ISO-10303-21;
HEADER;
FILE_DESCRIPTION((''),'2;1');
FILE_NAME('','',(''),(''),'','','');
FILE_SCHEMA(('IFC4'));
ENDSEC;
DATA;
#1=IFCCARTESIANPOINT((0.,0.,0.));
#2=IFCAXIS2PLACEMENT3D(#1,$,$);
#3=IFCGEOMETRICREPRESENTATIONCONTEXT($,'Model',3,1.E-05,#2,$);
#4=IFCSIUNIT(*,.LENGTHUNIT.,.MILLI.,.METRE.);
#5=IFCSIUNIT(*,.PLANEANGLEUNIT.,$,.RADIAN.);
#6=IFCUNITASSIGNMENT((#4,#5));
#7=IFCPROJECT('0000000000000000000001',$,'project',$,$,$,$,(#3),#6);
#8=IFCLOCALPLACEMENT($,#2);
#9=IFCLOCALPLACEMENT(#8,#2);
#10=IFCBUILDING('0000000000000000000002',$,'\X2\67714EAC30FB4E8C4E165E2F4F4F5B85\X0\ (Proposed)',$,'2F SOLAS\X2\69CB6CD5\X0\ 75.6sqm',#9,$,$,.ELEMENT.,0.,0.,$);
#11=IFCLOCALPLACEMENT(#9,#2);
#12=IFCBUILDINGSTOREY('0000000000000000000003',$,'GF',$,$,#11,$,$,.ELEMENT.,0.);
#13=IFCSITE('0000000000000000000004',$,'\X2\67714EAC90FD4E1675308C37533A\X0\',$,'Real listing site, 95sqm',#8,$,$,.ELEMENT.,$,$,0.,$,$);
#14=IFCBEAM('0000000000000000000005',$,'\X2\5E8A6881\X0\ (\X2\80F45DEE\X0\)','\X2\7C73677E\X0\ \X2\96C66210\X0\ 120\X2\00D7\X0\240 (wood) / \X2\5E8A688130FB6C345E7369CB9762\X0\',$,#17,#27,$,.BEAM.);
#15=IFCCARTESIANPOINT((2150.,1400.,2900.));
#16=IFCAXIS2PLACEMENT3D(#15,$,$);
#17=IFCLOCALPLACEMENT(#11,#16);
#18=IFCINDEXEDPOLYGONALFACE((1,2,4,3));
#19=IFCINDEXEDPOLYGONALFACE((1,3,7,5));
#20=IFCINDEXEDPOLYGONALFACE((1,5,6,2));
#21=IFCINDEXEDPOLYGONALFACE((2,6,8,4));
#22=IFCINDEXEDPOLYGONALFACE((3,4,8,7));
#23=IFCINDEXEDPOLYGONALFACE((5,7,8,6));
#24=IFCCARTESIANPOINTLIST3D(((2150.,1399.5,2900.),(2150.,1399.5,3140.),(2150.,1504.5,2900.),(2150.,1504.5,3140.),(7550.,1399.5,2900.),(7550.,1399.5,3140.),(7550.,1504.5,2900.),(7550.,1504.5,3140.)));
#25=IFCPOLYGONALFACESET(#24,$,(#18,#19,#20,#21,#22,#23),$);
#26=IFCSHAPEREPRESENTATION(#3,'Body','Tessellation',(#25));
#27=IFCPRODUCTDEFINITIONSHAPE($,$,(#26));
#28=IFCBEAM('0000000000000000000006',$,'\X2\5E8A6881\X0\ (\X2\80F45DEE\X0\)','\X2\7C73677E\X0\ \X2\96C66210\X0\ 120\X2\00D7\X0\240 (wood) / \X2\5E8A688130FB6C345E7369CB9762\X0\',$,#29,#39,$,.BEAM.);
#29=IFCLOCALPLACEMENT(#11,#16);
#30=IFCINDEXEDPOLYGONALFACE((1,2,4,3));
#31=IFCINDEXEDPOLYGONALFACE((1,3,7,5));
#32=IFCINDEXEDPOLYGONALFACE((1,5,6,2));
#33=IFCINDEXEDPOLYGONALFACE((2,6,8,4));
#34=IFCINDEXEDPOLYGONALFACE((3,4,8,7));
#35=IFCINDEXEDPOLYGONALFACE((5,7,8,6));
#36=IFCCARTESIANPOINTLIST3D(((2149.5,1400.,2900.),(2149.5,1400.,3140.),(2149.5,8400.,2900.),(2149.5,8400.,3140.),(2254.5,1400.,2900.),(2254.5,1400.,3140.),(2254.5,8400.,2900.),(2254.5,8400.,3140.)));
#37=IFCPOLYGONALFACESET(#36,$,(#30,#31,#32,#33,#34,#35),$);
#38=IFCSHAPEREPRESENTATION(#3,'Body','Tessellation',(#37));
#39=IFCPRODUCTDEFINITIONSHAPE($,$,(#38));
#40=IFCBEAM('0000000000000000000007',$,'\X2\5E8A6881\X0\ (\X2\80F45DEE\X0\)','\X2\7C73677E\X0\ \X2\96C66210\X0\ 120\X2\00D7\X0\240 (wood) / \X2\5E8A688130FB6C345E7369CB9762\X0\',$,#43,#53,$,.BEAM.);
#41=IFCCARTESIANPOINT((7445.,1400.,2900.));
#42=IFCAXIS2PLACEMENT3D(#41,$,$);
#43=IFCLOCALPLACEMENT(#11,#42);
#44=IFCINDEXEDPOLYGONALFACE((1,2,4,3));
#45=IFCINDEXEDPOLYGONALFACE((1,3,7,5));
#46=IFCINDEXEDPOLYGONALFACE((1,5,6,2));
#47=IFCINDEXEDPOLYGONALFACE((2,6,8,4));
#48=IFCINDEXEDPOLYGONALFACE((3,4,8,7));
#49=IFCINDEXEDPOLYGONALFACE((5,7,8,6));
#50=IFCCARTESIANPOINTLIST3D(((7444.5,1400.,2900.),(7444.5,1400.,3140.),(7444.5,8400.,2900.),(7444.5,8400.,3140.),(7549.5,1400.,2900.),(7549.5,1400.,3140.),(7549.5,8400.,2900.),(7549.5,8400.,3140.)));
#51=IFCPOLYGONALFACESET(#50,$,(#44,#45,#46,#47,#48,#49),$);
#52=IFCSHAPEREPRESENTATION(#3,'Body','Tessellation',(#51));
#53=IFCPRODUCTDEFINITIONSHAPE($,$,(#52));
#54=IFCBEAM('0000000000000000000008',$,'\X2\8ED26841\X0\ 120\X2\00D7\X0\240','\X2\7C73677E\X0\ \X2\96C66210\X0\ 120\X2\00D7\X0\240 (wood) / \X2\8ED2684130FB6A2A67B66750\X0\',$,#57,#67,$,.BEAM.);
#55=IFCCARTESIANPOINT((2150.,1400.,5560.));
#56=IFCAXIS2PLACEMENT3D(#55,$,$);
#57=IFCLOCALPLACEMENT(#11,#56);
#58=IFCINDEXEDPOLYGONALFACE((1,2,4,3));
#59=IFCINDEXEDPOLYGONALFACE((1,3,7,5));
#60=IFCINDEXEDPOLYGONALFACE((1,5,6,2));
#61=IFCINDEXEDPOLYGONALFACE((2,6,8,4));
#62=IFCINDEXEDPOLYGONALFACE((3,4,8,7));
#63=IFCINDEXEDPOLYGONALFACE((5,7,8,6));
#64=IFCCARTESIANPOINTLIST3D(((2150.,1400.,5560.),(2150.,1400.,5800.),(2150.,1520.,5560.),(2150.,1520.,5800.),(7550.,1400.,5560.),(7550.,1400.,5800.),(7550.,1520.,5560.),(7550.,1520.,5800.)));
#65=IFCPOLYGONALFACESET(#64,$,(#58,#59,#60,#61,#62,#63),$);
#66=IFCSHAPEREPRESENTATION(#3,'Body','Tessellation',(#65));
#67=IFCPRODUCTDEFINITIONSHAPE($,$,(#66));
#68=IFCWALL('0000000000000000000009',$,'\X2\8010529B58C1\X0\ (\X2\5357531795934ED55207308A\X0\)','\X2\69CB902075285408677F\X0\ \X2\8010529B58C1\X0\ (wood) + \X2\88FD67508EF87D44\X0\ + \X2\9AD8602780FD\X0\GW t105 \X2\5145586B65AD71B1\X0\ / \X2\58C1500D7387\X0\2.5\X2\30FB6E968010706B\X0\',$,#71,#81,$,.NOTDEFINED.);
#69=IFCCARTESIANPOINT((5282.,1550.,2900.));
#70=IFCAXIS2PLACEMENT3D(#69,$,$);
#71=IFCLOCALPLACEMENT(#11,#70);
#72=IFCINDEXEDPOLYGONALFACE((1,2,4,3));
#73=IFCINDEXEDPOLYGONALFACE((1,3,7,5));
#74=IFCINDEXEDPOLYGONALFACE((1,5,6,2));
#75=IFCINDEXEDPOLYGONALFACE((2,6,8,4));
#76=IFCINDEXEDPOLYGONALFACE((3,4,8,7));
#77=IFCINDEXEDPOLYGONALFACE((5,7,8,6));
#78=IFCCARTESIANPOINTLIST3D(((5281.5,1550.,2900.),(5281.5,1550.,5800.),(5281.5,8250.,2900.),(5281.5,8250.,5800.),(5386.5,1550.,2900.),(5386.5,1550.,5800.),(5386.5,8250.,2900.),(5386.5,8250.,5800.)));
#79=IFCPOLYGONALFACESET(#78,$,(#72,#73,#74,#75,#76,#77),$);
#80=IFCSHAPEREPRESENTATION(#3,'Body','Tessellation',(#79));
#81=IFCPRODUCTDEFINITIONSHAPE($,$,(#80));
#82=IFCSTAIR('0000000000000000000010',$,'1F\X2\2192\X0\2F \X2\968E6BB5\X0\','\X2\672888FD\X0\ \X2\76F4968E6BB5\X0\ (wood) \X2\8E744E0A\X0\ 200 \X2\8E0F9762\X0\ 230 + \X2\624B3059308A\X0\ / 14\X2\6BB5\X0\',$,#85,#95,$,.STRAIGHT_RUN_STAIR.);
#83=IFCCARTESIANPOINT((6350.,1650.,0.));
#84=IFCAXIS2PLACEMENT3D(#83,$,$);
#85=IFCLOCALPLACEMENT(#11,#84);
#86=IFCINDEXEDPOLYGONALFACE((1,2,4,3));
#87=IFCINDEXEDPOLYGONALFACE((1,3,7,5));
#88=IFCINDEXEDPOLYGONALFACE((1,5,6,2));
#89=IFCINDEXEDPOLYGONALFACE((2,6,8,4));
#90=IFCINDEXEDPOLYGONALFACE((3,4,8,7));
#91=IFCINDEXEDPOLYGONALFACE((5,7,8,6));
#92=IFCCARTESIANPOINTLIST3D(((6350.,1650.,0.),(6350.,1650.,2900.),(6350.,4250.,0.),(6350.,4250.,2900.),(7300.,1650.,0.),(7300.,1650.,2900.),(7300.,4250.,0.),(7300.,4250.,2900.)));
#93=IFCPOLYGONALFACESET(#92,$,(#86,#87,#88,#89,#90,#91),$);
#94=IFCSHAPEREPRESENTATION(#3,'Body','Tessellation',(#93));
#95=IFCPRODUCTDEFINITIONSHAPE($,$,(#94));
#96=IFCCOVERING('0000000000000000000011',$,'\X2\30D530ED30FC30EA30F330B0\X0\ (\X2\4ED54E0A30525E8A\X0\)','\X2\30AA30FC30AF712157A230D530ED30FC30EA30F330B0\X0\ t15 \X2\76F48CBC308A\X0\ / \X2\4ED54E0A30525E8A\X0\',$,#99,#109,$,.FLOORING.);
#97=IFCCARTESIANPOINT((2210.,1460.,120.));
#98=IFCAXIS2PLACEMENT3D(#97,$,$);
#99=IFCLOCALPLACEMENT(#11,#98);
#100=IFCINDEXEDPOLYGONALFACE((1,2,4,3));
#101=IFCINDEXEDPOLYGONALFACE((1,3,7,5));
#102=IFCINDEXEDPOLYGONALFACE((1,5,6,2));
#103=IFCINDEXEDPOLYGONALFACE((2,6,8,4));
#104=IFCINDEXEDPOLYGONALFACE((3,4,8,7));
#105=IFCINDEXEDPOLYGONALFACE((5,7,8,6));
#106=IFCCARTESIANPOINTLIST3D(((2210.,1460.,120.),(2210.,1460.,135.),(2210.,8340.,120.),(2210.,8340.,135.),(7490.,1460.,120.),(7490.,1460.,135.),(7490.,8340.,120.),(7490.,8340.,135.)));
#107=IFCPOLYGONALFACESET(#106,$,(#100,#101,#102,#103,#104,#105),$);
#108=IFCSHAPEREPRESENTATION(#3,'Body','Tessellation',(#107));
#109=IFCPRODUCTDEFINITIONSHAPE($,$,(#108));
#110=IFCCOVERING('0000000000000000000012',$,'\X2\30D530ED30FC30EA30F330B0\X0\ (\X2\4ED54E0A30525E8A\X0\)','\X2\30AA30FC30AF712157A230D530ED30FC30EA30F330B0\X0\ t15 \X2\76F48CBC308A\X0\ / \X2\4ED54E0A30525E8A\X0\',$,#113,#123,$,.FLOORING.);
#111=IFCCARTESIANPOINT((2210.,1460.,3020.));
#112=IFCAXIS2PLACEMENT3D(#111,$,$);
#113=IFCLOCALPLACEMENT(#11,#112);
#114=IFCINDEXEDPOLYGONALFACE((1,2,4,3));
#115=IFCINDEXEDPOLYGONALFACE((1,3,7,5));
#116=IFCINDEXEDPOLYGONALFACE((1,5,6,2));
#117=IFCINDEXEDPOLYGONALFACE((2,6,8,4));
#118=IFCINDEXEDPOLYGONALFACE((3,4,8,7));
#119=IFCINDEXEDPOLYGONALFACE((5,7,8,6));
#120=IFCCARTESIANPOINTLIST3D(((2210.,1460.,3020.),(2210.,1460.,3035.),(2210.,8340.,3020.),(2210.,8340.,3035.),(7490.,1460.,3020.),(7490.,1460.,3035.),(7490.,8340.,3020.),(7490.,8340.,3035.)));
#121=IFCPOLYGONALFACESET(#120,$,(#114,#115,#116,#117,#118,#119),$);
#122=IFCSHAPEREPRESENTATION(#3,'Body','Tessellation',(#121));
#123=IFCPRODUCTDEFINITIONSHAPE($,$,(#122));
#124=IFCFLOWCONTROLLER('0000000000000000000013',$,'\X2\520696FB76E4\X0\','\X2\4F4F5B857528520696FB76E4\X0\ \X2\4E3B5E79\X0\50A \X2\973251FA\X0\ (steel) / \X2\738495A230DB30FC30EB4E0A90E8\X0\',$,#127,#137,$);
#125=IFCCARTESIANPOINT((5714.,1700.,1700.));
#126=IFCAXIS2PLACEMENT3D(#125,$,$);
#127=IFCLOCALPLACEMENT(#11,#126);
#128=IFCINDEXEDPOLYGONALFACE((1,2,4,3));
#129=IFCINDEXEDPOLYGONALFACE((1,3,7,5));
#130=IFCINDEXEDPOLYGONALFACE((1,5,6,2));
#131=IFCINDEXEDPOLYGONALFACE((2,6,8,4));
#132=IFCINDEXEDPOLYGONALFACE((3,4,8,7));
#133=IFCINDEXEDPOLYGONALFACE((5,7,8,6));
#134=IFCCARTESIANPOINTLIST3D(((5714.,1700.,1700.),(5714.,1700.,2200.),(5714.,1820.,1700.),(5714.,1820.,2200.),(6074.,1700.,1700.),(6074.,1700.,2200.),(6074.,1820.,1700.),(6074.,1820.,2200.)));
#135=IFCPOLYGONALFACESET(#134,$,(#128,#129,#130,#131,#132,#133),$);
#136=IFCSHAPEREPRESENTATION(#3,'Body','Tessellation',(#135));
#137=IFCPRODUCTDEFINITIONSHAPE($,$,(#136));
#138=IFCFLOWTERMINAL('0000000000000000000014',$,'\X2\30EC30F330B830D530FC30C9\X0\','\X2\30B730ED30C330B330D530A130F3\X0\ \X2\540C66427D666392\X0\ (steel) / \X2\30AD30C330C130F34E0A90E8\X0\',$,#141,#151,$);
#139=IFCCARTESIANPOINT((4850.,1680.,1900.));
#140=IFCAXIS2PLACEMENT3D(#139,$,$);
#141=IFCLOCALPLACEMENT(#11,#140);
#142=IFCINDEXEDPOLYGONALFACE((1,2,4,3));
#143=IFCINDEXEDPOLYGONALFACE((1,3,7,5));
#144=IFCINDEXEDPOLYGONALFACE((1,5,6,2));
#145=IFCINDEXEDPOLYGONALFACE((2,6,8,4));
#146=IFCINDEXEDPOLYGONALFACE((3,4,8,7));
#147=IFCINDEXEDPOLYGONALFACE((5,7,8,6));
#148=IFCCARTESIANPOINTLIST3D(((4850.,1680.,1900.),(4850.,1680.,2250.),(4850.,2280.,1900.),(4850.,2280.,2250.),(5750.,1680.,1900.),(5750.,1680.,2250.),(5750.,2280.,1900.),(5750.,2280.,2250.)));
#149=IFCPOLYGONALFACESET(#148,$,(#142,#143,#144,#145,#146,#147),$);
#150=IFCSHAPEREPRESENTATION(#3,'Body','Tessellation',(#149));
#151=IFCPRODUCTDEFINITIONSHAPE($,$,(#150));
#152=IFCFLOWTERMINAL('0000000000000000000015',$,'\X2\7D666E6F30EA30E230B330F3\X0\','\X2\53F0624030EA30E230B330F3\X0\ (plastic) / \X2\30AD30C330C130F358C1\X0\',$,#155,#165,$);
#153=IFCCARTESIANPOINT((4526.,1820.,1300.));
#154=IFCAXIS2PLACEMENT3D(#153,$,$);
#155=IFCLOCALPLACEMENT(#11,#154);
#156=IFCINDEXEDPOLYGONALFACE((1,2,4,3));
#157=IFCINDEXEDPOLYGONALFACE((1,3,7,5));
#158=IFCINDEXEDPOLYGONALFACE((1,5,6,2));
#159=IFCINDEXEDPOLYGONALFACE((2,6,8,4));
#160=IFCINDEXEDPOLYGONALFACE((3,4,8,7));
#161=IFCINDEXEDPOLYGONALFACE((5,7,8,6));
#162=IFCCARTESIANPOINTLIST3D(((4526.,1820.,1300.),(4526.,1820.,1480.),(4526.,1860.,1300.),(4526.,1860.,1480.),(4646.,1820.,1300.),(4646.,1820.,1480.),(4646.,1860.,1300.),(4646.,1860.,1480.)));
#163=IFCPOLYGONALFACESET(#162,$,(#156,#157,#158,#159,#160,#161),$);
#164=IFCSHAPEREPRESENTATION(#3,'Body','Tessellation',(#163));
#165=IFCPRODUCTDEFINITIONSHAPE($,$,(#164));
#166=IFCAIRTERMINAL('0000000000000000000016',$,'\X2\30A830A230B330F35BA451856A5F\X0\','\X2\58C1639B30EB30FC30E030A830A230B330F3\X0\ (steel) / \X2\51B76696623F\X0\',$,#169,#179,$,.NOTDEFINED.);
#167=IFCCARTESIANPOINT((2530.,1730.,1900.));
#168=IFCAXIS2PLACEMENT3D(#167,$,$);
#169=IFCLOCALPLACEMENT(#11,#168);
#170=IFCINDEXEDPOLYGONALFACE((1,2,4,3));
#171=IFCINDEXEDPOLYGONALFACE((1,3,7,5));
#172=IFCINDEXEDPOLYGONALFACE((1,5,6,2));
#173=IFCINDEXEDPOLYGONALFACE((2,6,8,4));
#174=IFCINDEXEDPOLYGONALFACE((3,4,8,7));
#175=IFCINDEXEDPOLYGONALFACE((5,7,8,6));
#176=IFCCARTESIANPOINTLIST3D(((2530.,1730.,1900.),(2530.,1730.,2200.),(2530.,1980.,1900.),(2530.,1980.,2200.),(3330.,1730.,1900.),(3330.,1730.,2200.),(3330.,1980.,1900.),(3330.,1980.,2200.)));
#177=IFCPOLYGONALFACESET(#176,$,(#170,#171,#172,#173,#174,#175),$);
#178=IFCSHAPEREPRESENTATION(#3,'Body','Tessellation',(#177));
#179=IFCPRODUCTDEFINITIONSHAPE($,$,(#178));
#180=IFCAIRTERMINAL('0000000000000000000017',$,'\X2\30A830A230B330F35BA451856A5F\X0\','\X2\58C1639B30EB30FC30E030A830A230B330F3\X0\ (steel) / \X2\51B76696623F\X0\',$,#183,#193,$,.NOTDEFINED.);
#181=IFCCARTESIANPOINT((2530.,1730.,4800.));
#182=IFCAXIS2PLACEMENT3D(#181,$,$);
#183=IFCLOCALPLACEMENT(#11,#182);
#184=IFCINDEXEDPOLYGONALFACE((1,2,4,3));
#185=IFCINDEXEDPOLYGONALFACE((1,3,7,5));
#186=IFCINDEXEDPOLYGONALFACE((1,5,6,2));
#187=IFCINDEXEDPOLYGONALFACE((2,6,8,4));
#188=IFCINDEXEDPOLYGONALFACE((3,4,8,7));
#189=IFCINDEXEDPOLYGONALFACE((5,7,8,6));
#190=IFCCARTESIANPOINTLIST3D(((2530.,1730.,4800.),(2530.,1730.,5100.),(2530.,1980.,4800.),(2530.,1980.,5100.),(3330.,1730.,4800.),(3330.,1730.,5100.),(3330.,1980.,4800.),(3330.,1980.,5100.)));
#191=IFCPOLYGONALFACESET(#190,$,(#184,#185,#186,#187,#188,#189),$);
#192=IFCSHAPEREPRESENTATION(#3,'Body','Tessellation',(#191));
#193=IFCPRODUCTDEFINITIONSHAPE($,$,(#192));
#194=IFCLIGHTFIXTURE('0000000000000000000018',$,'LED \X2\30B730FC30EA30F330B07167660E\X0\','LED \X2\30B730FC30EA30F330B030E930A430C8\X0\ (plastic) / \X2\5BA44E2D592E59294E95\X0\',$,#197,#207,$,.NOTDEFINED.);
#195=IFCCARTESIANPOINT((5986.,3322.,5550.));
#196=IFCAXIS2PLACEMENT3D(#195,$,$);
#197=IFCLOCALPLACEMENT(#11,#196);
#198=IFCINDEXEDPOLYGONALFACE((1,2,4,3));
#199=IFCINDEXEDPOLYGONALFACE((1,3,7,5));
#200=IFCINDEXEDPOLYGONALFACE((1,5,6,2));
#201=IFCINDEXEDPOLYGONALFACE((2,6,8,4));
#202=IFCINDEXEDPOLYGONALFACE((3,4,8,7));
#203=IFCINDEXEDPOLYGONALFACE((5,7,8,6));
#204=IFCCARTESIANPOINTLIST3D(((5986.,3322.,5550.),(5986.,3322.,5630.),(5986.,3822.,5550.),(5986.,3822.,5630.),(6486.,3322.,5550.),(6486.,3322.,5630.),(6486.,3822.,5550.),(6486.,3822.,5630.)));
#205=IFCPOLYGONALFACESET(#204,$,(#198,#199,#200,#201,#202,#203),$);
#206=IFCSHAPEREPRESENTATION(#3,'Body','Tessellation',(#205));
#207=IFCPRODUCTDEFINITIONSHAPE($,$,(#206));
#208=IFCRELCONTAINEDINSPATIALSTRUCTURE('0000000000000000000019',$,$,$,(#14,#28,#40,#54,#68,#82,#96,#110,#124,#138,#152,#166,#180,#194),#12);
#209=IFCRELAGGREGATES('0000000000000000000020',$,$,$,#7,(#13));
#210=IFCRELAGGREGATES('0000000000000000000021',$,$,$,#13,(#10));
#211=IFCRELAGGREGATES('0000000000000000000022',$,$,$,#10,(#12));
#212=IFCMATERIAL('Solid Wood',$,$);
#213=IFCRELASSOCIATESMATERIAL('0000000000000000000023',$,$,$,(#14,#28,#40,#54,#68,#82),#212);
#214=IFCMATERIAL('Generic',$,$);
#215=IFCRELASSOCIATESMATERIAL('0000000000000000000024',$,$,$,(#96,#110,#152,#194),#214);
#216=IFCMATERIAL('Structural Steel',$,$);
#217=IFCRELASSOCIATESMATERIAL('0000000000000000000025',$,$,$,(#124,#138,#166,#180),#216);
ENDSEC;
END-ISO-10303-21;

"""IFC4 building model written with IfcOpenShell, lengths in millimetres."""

from ifc_helpers import new_model, si_unit, frame, frame_2d, origin, place, context, project, spatial, rectangle, extrude, material, element, save


model = new_model("IFC4")

# Units and contexts
model_context = context("Model", 3, precision=1e-05, world=origin())
ifc_project = project(units=[si_unit("LENGTHUNIT", "METRE", prefix="MILLI"), si_unit("PLANEANGLEUNIT", "RADIAN")], contexts=[model_context])

# Site, building, storey
site_placement = place(None, origin())
site = spatial("IfcSite", under=ifc_project, at=site_placement, Name="東京都世田谷区", ObjectType="Real listing site, 95sqm", CompositionType="ELEMENT", RefElevation=0.0)
building_placement = place(site_placement, origin())
building = spatial("IfcBuilding", under=site, at=building_placement, Name="東京・二世帯住宅 (Proposed)", ObjectType="2F SOLAS構法 75.6sqm", CompositionType="ELEMENT", ElevationOfRefHeight=0.0, ElevationOfTerrain=0.0)
storey_placement = place(building_placement, origin())
storey = spatial("IfcBuildingStorey", under=building, at=storey_placement, Name="GF", CompositionType="ELEMENT", Elevation=0.0)

# Shared definitions
ifc_material_1 = material(Name="Solid Wood")

# Beams
beam_1_placement = place(storey_placement, frame((2150.0, 1400.0, 2900.0)))
element("IfcBeam", 1, at=beam_1_placement, inside=storey, material=ifc_material_1, Name="床梁 (胴差)", Description="米松 集成 120×240 (wood) / 床梁・水平構面", PredefinedType="BEAM", context=model_context, shape_type="SweptSolid", body=[
    extrude(rectangle(XDim=5400.0, YDim=105.0, at=frame_2d((2700.0, 52.0))), frame((2150.0, 1400.0, 2900.0)), (0.0, 0.0, 1.0), 240.0),
])
beam_2_placement = place(storey_placement, frame((2150.0, 1400.0, 2900.0)))
element("IfcBeam", 2, at=beam_2_placement, inside=storey, material=ifc_material_1, Name="床梁 (胴差)", Description="米松 集成 120×240 (wood) / 床梁・水平構面", PredefinedType="BEAM", context=model_context, shape_type="SweptSolid", body=[
    extrude(rectangle(XDim=105.0, YDim=7000.0, at=frame_2d((52.0, 3500.0))), frame((2150.0, 1400.0, 2900.0)), (0.0, 0.0, 1.0), 240.0),
])
beam_3_placement = place(storey_placement, frame((7445.0, 1400.0, 2900.0)))
element("IfcBeam", 3, at=beam_3_placement, inside=storey, material=ifc_material_1, Name="床梁 (胴差)", Description="米松 集成 120×240 (wood) / 床梁・水平構面", PredefinedType="BEAM", context=model_context, shape_type="SweptSolid", body=[
    extrude(rectangle(XDim=105.0, YDim=7000.0, at=frame_2d((52.0, 3500.0))), frame((7445.0, 1400.0, 2900.0)), (0.0, 0.0, 1.0), 240.0),
])
beam_4_placement = place(storey_placement, frame((2150.0, 1400.0, 5560.0)))
element("IfcBeam", 4, at=beam_4_placement, inside=storey, material=ifc_material_1, Name="軒桁 120×240", Description="米松 集成 120×240 (wood) / 軒桁・横架材", PredefinedType="BEAM", context=model_context, shape_type="SweptSolid", body=[
    extrude(rectangle(XDim=5400.0, YDim=120.0, at=frame_2d((2700.0, 60.0))), frame((2150.0, 1400.0, 5560.0)), (0.0, 0.0, 1.0), 240.0),
])

# Wall
wall_1_placement = place(storey_placement, frame((5282.0, 1550.0, 2900.0)))
element("IfcWall", 5, at=wall_1_placement, inside=storey, material=ifc_material_1, Name="耐力壁 (南北間仕切り)", Description="構造用合板 耐力壁 (wood) + 製材軸組 + 高性能GW t105 充填断熱 / 壁倍率2.5・準耐火", PredefinedType="NOTDEFINED", context=model_context, shape_type="SweptSolid", body=[
    extrude(rectangle(XDim=105.0, YDim=6700.0, at=frame_2d((52.0, 3350.0))), frame((5282.0, 1550.0, 2900.0)), (0.0, 0.0, 1.0), 2900.0),
])

# Stair
stair_placement = place(storey_placement, frame((6350.0, 1650.0, 0.0)))
element("IfcStair", 6, at=stair_placement, inside=storey, material=ifc_material_1, Name="1F→2F 階段", Description="木製 直階段 (wood) 蹴上 200 踏面 230 + 手すり / 14段", PredefinedType="STRAIGHT_RUN_STAIR", context=model_context, shape_type="SweptSolid", body=[
    extrude(rectangle(XDim=950.0, YDim=2600.0, at=frame_2d((475.0, 1300.0))), frame((6350.0, 1650.0, 0.0)), (0.0, 0.0, 1.0), 2900.0),
])

# Coverings
ifc_material_2 = material(Name="Generic")
covering_1_placement = place(storey_placement, frame((2210.0, 1460.0, 120.0)))
element("IfcCovering", 7, at=covering_1_placement, inside=storey, material=ifc_material_2, Name="フローリング (仕上げ床)", Description="オーク無垢フローリング t15 直貼り / 仕上げ床", PredefinedType="FLOORING", context=model_context, shape_type="SweptSolid", body=[
    extrude(rectangle(XDim=5280.0, YDim=6880.0, at=frame_2d((2640.0, 3440.0))), frame((2210.0, 1460.0, 120.0)), (0.0, 0.0, 1.0), 15.0),
])
covering_2_placement = place(storey_placement, frame((2210.0, 1460.0, 3020.0)))
element("IfcCovering", 8, at=covering_2_placement, inside=storey, material=ifc_material_2, Name="フローリング (仕上げ床)", Description="オーク無垢フローリング t15 直貼り / 仕上げ床", PredefinedType="FLOORING", context=model_context, shape_type="SweptSolid", body=[
    extrude(rectangle(XDim=5280.0, YDim=6880.0, at=frame_2d((2640.0, 3440.0))), frame((2210.0, 1460.0, 3020.0)), (0.0, 0.0, 1.0), 15.0),
])

# Flow controller
ifc_material_3 = material(Name="Structural Steel")
flow_controller_placement = place(storey_placement, frame((5714.0, 1700.0, 1700.0)))
element("IfcFlowController", 9, at=flow_controller_placement, inside=storey, material=ifc_material_3, Name="分電盤", Description="住宅用分電盤 主幹50A 露出 (steel) / 玄関ホール上部", context=model_context, shape_type="SweptSolid", body=[
    extrude(rectangle(XDim=360.0, YDim=120.0, at=frame_2d((180.0, 60.0))), frame((5714.0, 1700.0, 1700.0)), (0.0, 0.0, 1.0), 500.0),
])

# Flow terminals
flow_terminal_1_placement = place(storey_placement, frame((4850.0, 1680.0, 1900.0)))
element("IfcFlowTerminal", 10, at=flow_terminal_1_placement, inside=storey, material=ifc_material_3, Name="レンジフード", Description="シロッコファン 同時給排 (steel) / キッチン上部", context=model_context, shape_type="SweptSolid", body=[
    extrude(rectangle(XDim=900.0, YDim=600.0, at=frame_2d((450.0, 300.0))), frame((4850.0, 1680.0, 1900.0)), (0.0, 0.0, 1.0), 350.0),
])
flow_terminal_2_placement = place(storey_placement, frame((4526.0, 1820.0, 1300.0)))
element("IfcFlowTerminal", 11, at=flow_terminal_2_placement, inside=storey, material=ifc_material_2, Name="給湯リモコン", Description="台所リモコン (plastic) / キッチン壁", context=model_context, shape_type="SweptSolid", body=[
    extrude(rectangle(XDim=120.0, YDim=40.0, at=frame_2d((60.0, 20.0))), frame((4526.0, 1820.0, 1300.0)), (0.0, 0.0, 1.0), 180.0),
])

# Air terminals
air_terminal_1_placement = place(storey_placement, frame((2530.0, 1730.0, 1900.0)))
element("IfcAirTerminal", 12, at=air_terminal_1_placement, inside=storey, material=ifc_material_3, Name="エアコン室内機", Description="壁掛ルームエアコン (steel) / 冷暖房", PredefinedType="NOTDEFINED", context=model_context, shape_type="SweptSolid", body=[
    extrude(rectangle(XDim=800.0, YDim=250.0, at=frame_2d((400.0, 125.0))), frame((2530.0, 1730.0, 1900.0)), (0.0, 0.0, 1.0), 300.0),
])
air_terminal_2_placement = place(storey_placement, frame((2530.0, 1730.0, 4800.0)))
element("IfcAirTerminal", 13, at=air_terminal_2_placement, inside=storey, material=ifc_material_3, Name="エアコン室内機", Description="壁掛ルームエアコン (steel) / 冷暖房", PredefinedType="NOTDEFINED", context=model_context, shape_type="SweptSolid", body=[
    extrude(rectangle(XDim=800.0, YDim=250.0, at=frame_2d((400.0, 125.0))), frame((2530.0, 1730.0, 4800.0)), (0.0, 0.0, 1.0), 300.0),
])

# Light fixture
light_fixture_placement = place(storey_placement, frame((5986.0, 3322.0, 5550.0)))
element("IfcLightFixture", 14, at=light_fixture_placement, inside=storey, material=ifc_material_2, Name="LED シーリング照明", Description="LED シーリングライト (plastic) / 室中央天井", PredefinedType="NOTDEFINED", context=model_context, shape_type="SweptSolid", body=[
    extrude(rectangle(XDim=500.0, YDim=500.0, at=frame_2d((250.0, 250.0))), frame((5986.0, 3322.0, 5550.0)), (0.0, 0.0, 1.0), 80.0),
])

save(model, "model.ifc")
